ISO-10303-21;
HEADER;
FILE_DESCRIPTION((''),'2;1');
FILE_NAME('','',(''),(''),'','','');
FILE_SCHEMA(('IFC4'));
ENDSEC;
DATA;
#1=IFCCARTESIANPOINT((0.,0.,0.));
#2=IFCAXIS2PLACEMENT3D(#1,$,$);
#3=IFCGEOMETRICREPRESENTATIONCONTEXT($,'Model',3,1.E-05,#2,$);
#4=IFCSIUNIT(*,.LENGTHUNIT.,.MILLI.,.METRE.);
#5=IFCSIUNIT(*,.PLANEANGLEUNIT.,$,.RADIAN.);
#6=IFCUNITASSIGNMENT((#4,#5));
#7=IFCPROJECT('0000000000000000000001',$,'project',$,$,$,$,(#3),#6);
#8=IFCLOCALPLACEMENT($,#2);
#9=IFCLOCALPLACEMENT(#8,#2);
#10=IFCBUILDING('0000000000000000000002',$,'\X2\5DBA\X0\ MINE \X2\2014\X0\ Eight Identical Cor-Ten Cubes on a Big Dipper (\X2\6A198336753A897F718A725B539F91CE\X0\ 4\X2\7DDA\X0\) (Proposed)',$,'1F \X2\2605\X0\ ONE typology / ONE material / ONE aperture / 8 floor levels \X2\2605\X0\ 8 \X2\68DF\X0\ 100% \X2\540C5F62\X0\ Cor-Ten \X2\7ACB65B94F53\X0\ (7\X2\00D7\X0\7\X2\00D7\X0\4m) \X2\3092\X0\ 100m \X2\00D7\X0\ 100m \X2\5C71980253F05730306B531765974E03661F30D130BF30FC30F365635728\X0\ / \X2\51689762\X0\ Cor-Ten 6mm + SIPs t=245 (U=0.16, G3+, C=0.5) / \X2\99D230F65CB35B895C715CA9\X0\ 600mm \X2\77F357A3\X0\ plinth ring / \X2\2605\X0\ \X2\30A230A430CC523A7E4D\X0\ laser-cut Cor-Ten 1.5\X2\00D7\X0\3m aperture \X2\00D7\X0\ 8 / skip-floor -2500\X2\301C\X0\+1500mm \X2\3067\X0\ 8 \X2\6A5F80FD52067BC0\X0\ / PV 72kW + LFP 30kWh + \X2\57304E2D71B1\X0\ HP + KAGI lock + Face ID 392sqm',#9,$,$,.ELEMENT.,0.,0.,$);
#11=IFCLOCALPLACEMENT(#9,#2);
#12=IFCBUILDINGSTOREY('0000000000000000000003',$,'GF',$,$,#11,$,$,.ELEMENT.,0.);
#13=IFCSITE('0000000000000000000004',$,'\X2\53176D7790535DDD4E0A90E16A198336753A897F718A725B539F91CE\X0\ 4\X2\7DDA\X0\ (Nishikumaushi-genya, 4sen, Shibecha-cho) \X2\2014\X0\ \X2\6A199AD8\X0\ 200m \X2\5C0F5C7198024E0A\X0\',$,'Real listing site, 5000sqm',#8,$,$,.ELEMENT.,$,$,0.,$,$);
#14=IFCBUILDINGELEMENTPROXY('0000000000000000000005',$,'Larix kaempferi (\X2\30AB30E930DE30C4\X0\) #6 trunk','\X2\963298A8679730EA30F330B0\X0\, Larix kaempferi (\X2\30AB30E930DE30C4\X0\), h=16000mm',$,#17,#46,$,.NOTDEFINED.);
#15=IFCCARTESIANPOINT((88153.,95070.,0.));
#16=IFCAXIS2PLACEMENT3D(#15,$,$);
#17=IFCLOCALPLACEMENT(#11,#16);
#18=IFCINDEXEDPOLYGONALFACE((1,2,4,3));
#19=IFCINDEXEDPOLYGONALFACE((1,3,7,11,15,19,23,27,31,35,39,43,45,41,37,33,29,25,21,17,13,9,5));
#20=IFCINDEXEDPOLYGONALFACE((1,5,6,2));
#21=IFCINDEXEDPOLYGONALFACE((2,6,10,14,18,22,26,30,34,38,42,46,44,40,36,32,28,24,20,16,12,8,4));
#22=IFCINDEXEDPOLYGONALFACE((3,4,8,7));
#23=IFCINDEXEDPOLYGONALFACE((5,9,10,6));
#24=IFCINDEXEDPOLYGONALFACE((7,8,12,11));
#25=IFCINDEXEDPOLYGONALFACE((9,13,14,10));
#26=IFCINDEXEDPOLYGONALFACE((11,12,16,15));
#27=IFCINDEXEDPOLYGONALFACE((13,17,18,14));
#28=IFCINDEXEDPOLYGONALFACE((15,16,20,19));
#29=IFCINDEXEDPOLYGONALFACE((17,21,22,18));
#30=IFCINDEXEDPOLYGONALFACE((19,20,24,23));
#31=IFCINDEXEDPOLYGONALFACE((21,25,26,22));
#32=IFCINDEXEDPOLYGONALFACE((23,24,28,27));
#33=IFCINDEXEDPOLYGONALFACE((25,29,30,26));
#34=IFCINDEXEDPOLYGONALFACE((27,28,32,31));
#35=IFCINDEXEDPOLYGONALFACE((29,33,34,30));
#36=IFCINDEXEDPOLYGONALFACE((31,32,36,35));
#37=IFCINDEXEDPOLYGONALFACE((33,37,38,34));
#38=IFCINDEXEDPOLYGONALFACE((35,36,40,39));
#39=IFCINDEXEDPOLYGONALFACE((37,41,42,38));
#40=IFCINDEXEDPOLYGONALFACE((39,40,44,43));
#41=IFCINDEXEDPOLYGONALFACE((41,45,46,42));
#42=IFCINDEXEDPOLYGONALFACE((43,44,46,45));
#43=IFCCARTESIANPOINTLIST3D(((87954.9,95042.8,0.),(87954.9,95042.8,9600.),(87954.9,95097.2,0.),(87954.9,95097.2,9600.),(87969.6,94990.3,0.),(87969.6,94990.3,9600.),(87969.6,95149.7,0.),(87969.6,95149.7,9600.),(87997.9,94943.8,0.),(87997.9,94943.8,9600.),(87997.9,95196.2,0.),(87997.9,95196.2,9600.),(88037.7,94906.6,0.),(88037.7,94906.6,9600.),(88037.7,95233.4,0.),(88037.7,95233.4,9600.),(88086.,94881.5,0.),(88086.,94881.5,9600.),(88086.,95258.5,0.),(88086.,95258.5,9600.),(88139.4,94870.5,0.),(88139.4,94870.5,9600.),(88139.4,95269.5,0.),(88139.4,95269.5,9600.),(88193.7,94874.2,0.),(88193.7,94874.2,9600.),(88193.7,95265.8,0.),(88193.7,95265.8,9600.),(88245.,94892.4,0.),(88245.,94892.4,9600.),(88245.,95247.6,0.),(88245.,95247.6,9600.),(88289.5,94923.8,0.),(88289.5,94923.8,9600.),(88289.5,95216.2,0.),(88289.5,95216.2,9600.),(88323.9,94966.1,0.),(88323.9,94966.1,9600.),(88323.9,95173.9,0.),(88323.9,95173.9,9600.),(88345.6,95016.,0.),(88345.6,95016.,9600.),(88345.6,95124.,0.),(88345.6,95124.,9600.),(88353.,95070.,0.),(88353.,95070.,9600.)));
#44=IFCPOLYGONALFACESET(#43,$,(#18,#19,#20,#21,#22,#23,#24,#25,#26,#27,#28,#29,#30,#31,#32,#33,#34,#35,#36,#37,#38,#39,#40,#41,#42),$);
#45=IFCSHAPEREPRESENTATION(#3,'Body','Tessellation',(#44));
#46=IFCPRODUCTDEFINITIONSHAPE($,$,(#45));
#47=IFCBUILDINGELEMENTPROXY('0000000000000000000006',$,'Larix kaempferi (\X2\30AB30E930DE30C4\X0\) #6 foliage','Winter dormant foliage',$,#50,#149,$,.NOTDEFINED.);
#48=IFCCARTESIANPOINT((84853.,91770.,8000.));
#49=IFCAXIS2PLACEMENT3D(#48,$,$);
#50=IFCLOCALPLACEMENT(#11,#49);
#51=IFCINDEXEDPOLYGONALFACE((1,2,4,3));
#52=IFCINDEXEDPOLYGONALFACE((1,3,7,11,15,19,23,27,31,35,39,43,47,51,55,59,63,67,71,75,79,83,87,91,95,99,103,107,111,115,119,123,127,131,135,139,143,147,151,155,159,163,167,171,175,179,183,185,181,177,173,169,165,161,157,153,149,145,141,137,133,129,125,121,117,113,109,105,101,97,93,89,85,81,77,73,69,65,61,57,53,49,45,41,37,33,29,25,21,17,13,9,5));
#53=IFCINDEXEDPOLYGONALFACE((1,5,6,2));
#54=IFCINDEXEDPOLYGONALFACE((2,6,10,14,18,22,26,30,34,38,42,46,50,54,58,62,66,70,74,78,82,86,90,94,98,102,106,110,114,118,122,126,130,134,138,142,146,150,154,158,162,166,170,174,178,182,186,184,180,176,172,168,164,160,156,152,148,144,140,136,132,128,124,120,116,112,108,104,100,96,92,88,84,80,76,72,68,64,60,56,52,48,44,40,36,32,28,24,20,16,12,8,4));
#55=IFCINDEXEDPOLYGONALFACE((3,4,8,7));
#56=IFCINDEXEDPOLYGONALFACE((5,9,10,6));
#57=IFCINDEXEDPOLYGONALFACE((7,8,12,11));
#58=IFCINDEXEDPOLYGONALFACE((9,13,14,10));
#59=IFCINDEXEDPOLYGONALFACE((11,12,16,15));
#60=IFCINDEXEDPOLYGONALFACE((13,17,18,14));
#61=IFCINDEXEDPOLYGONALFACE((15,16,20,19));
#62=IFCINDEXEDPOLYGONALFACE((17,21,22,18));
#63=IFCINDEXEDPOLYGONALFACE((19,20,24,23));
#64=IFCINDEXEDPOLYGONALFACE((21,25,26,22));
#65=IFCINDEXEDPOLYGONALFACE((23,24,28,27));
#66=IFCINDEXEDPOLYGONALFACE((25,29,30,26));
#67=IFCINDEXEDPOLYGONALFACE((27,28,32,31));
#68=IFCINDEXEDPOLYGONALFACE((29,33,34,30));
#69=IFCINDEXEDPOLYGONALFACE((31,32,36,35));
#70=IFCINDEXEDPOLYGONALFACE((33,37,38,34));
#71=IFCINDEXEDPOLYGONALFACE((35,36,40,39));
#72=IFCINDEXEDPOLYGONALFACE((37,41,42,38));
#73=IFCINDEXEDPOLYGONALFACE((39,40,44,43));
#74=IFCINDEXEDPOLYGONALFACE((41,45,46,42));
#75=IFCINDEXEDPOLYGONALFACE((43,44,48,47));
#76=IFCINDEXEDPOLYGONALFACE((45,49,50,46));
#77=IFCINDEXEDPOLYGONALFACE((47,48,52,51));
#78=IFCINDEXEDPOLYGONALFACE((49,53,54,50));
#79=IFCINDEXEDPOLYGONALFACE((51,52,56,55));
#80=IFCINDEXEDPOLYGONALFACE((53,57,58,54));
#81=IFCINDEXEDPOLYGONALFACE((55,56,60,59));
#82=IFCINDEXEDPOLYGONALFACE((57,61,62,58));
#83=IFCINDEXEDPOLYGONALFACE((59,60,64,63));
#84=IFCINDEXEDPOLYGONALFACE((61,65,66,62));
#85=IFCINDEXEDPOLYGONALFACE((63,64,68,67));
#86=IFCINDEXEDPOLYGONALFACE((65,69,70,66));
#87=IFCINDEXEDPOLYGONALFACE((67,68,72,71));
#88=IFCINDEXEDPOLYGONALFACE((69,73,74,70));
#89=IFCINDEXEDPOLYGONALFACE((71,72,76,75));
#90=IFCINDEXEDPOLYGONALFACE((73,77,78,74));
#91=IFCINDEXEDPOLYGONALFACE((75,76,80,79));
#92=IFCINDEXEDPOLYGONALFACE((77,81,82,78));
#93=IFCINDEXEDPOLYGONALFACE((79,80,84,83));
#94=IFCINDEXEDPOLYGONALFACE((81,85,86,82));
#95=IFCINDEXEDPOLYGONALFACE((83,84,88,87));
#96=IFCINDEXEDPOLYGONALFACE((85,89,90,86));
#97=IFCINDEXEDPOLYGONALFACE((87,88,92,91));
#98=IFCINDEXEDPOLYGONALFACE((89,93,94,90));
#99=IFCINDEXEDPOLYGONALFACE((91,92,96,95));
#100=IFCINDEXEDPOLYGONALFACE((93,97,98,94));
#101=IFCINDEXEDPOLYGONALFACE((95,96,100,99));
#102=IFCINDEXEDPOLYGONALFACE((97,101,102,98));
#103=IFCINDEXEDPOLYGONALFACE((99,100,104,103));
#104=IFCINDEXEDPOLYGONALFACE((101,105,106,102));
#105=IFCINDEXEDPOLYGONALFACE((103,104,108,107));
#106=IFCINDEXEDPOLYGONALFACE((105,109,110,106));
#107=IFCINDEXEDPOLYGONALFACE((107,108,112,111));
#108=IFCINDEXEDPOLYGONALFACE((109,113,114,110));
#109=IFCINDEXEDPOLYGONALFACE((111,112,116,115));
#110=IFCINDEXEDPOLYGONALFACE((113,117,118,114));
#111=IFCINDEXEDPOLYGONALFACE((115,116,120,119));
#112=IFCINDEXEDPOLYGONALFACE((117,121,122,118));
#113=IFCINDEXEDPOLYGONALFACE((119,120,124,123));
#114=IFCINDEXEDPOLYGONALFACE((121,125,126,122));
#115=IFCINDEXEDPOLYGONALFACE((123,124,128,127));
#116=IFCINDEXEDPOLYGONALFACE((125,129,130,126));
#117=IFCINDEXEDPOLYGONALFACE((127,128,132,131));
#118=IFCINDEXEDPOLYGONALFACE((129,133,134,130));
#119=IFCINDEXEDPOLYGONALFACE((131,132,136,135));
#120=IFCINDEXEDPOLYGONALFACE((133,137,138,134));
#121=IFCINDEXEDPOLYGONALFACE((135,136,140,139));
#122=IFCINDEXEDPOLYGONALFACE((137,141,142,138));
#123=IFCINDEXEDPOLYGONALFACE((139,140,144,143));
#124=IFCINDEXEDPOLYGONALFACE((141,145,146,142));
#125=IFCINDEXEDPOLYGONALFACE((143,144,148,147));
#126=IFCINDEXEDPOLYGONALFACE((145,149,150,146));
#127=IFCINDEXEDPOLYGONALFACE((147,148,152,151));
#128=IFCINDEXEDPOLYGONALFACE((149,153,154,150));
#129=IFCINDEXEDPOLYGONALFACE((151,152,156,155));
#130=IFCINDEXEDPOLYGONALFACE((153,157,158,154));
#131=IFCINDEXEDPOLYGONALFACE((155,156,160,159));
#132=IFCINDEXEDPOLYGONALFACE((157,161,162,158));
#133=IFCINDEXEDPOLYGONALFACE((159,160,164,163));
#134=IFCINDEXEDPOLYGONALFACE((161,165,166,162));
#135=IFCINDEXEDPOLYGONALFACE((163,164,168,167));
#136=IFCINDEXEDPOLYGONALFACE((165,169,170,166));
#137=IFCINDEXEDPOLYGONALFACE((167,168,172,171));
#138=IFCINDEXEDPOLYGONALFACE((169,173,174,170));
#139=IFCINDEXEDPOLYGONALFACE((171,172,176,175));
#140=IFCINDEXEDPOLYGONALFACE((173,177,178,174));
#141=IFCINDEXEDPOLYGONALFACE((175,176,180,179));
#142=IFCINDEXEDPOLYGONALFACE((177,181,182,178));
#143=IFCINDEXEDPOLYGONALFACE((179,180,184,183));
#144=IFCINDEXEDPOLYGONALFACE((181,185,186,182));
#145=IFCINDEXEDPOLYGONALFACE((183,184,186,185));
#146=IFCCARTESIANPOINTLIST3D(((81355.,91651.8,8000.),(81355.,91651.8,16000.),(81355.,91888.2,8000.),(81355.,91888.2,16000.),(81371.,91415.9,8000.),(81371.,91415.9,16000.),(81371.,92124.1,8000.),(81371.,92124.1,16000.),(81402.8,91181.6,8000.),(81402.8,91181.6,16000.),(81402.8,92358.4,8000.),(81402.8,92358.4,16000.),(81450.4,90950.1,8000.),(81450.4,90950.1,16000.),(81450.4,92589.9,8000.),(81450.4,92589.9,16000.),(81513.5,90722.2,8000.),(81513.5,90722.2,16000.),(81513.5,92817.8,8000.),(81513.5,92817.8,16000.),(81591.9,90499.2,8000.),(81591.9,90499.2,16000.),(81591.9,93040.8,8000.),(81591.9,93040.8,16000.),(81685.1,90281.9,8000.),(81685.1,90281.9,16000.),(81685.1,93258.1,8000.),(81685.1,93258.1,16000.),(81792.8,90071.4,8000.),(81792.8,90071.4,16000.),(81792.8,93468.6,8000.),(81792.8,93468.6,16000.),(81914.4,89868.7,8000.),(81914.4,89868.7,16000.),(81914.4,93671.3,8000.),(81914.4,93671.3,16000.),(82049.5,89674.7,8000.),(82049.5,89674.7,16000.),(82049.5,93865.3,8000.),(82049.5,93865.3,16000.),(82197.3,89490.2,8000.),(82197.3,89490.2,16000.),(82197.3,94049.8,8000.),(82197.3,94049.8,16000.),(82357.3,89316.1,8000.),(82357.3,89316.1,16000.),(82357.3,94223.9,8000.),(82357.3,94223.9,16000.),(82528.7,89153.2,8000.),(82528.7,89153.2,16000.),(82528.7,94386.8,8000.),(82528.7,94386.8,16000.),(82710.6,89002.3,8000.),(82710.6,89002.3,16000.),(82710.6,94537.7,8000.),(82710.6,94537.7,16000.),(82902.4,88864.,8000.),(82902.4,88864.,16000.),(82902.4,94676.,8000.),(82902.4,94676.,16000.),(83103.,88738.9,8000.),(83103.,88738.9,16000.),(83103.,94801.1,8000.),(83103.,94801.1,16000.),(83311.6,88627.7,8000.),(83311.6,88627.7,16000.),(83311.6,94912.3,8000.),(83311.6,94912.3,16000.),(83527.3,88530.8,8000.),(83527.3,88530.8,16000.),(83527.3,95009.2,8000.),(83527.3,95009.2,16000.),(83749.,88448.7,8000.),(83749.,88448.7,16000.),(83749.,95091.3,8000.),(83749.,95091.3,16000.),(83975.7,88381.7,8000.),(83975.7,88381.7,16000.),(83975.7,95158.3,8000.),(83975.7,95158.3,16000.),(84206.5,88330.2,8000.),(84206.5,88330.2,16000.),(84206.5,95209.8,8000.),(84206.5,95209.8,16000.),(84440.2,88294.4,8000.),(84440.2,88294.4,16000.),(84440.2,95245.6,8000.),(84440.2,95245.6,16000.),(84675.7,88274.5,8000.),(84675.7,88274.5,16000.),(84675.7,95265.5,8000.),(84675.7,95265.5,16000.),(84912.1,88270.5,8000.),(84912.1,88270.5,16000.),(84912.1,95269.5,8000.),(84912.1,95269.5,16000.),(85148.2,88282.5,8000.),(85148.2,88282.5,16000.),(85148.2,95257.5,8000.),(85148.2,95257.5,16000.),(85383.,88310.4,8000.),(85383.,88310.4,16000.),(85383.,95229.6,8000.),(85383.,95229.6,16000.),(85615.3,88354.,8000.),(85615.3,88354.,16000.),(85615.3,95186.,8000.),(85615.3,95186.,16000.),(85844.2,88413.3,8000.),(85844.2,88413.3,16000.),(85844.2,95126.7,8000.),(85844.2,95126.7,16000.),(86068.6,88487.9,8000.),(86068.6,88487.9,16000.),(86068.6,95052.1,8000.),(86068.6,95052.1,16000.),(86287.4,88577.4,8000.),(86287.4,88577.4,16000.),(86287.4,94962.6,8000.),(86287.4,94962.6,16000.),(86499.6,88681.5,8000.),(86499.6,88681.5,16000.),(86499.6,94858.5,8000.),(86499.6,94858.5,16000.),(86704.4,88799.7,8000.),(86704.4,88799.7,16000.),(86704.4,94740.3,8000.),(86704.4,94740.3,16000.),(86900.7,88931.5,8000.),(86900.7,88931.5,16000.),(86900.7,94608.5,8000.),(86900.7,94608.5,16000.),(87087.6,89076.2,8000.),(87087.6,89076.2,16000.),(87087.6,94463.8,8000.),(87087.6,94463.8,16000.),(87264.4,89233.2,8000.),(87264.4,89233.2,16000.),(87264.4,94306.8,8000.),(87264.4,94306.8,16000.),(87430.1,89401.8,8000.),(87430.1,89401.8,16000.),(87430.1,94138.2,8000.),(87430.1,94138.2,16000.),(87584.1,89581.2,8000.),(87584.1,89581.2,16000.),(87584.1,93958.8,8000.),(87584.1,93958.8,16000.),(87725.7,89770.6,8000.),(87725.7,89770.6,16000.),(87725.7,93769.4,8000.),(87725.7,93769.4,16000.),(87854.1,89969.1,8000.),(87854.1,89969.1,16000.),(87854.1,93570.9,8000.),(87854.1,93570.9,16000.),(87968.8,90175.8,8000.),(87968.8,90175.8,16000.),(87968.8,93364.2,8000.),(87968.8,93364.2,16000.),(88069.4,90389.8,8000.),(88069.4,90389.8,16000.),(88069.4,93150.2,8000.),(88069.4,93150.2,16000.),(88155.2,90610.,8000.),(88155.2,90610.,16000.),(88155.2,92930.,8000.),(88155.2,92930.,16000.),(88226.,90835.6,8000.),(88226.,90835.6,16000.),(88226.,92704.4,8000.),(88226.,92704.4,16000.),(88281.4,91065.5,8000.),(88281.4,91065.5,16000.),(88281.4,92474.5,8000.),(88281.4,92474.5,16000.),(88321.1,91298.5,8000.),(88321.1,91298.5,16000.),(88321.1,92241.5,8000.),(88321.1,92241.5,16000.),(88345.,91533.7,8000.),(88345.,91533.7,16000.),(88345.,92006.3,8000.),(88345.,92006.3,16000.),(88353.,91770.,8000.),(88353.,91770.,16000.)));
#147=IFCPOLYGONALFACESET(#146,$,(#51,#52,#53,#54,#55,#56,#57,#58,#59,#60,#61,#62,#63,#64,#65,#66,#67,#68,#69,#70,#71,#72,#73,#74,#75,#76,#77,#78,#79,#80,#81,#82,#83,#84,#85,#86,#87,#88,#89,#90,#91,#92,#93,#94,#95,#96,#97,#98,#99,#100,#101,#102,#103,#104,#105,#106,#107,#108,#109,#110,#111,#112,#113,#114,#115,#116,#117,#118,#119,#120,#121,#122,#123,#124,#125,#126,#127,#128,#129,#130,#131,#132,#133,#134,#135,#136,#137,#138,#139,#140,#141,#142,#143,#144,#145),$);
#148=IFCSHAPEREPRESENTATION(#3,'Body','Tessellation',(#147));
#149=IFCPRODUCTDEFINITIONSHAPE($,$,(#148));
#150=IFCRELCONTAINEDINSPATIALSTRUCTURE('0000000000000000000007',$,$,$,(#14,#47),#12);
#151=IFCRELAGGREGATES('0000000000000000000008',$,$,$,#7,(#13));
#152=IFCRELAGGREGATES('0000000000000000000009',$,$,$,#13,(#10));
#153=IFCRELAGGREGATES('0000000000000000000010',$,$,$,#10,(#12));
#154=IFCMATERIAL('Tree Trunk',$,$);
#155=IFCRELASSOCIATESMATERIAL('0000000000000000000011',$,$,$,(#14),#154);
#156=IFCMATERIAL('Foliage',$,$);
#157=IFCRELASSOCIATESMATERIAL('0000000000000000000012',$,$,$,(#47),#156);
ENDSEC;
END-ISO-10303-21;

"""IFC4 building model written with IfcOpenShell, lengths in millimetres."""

from ifc_helpers import new_model, si_unit, frame, origin, origin_2d, place, context, project, spatial, circle, extrude, material, element, save


model = new_model("IFC4")

# Units and contexts
model_context = context("Model", 3, precision=1e-05, world=origin())
ifc_project = project(units=[si_unit("LENGTHUNIT", "METRE", prefix="MILLI"), si_unit("PLANEANGLEUNIT", "RADIAN")], contexts=[model_context])

# Site, building, storey
site_placement = place(None, origin())
site = spatial("IfcSite", under=ifc_project, at=site_placement, Name="北海道川上郡標茶町西熊牛原野 4線 (Nishikumaushi-genya, 4sen, Shibecha-cho) — 標高 200m 小山頂上", ObjectType="Real listing site, 5000sqm", CompositionType="ELEMENT", RefElevation=0.0)
building_placement = place(site_placement, origin())
building = spatial("IfcBuilding", under=site, at=building_placement, Name="嶺 MINE — Eight Identical Cor-Ten Cubes on a Big Dipper (標茶町西熊牛原野 4線) (Proposed)", ObjectType="1F ★ ONE typology / ONE material / ONE aperture / 8 floor levels ★ 8 棟 100% 同形 Cor-Ten 立方体 (7×7×4m) を 100m × 100m 山頂台地に北斗七星パターン散在 / 全面 Cor-Ten 6mm + SIPs t=245 (U=0.16, G3+, C=0.5) / 駒ヶ岳安山岩 600mm 石垣 plinth ring / ★ アイヌ刺繍 laser-cut Cor-Ten 1.5×3m aperture × 8 / skip-floor -2500〜+1500mm で 8 機能分節 / PV 72kW + LFP 30kWh + 地中熱 HP + KAGI lock + Face ID 392sqm", CompositionType="ELEMENT", ElevationOfRefHeight=0.0, ElevationOfTerrain=0.0)
storey_placement = place(building_placement, origin())
storey = spatial("IfcBuildingStorey", under=building, at=storey_placement, Name="GF", CompositionType="ELEMENT", Elevation=0.0)

# Building element proxies
ifc_material_1 = material(Name="Tree Trunk")
ifc_material_2 = material(Name="Foliage")
proxy_1_placement = place(storey_placement, frame((88153.0, 95070.0, 0.0)))
element("IfcBuildingElementProxy", 1, at=proxy_1_placement, inside=storey, material=ifc_material_1, Name="Larix kaempferi (カラマツ) #6 trunk", Description="防風林リング, Larix kaempferi (カラマツ), h=16000mm", PredefinedType="NOTDEFINED", context=model_context, shape_type="SweptSolid", body=[
    extrude(circle(Radius=200.0, at=origin_2d()), frame((88153.0, 95070.0, 0.0)), (0.0, 0.0, 1.0), 9600.0),
])
proxy_2_placement = place(storey_placement, frame((84853.0, 91770.0, 8000.0)))
element("IfcBuildingElementProxy", 2, at=proxy_2_placement, inside=storey, material=ifc_material_2, Name="Larix kaempferi (カラマツ) #6 foliage", Description="Winter dormant foliage", PredefinedType="NOTDEFINED", context=model_context, shape_type="SweptSolid", body=[
    extrude(circle(Radius=3500.0, at=origin_2d()), frame((84853.0, 91770.0, 8000.0)), (0.0, 0.0, 1.0), 8000.0),
])

save(model, "model.ifc")
